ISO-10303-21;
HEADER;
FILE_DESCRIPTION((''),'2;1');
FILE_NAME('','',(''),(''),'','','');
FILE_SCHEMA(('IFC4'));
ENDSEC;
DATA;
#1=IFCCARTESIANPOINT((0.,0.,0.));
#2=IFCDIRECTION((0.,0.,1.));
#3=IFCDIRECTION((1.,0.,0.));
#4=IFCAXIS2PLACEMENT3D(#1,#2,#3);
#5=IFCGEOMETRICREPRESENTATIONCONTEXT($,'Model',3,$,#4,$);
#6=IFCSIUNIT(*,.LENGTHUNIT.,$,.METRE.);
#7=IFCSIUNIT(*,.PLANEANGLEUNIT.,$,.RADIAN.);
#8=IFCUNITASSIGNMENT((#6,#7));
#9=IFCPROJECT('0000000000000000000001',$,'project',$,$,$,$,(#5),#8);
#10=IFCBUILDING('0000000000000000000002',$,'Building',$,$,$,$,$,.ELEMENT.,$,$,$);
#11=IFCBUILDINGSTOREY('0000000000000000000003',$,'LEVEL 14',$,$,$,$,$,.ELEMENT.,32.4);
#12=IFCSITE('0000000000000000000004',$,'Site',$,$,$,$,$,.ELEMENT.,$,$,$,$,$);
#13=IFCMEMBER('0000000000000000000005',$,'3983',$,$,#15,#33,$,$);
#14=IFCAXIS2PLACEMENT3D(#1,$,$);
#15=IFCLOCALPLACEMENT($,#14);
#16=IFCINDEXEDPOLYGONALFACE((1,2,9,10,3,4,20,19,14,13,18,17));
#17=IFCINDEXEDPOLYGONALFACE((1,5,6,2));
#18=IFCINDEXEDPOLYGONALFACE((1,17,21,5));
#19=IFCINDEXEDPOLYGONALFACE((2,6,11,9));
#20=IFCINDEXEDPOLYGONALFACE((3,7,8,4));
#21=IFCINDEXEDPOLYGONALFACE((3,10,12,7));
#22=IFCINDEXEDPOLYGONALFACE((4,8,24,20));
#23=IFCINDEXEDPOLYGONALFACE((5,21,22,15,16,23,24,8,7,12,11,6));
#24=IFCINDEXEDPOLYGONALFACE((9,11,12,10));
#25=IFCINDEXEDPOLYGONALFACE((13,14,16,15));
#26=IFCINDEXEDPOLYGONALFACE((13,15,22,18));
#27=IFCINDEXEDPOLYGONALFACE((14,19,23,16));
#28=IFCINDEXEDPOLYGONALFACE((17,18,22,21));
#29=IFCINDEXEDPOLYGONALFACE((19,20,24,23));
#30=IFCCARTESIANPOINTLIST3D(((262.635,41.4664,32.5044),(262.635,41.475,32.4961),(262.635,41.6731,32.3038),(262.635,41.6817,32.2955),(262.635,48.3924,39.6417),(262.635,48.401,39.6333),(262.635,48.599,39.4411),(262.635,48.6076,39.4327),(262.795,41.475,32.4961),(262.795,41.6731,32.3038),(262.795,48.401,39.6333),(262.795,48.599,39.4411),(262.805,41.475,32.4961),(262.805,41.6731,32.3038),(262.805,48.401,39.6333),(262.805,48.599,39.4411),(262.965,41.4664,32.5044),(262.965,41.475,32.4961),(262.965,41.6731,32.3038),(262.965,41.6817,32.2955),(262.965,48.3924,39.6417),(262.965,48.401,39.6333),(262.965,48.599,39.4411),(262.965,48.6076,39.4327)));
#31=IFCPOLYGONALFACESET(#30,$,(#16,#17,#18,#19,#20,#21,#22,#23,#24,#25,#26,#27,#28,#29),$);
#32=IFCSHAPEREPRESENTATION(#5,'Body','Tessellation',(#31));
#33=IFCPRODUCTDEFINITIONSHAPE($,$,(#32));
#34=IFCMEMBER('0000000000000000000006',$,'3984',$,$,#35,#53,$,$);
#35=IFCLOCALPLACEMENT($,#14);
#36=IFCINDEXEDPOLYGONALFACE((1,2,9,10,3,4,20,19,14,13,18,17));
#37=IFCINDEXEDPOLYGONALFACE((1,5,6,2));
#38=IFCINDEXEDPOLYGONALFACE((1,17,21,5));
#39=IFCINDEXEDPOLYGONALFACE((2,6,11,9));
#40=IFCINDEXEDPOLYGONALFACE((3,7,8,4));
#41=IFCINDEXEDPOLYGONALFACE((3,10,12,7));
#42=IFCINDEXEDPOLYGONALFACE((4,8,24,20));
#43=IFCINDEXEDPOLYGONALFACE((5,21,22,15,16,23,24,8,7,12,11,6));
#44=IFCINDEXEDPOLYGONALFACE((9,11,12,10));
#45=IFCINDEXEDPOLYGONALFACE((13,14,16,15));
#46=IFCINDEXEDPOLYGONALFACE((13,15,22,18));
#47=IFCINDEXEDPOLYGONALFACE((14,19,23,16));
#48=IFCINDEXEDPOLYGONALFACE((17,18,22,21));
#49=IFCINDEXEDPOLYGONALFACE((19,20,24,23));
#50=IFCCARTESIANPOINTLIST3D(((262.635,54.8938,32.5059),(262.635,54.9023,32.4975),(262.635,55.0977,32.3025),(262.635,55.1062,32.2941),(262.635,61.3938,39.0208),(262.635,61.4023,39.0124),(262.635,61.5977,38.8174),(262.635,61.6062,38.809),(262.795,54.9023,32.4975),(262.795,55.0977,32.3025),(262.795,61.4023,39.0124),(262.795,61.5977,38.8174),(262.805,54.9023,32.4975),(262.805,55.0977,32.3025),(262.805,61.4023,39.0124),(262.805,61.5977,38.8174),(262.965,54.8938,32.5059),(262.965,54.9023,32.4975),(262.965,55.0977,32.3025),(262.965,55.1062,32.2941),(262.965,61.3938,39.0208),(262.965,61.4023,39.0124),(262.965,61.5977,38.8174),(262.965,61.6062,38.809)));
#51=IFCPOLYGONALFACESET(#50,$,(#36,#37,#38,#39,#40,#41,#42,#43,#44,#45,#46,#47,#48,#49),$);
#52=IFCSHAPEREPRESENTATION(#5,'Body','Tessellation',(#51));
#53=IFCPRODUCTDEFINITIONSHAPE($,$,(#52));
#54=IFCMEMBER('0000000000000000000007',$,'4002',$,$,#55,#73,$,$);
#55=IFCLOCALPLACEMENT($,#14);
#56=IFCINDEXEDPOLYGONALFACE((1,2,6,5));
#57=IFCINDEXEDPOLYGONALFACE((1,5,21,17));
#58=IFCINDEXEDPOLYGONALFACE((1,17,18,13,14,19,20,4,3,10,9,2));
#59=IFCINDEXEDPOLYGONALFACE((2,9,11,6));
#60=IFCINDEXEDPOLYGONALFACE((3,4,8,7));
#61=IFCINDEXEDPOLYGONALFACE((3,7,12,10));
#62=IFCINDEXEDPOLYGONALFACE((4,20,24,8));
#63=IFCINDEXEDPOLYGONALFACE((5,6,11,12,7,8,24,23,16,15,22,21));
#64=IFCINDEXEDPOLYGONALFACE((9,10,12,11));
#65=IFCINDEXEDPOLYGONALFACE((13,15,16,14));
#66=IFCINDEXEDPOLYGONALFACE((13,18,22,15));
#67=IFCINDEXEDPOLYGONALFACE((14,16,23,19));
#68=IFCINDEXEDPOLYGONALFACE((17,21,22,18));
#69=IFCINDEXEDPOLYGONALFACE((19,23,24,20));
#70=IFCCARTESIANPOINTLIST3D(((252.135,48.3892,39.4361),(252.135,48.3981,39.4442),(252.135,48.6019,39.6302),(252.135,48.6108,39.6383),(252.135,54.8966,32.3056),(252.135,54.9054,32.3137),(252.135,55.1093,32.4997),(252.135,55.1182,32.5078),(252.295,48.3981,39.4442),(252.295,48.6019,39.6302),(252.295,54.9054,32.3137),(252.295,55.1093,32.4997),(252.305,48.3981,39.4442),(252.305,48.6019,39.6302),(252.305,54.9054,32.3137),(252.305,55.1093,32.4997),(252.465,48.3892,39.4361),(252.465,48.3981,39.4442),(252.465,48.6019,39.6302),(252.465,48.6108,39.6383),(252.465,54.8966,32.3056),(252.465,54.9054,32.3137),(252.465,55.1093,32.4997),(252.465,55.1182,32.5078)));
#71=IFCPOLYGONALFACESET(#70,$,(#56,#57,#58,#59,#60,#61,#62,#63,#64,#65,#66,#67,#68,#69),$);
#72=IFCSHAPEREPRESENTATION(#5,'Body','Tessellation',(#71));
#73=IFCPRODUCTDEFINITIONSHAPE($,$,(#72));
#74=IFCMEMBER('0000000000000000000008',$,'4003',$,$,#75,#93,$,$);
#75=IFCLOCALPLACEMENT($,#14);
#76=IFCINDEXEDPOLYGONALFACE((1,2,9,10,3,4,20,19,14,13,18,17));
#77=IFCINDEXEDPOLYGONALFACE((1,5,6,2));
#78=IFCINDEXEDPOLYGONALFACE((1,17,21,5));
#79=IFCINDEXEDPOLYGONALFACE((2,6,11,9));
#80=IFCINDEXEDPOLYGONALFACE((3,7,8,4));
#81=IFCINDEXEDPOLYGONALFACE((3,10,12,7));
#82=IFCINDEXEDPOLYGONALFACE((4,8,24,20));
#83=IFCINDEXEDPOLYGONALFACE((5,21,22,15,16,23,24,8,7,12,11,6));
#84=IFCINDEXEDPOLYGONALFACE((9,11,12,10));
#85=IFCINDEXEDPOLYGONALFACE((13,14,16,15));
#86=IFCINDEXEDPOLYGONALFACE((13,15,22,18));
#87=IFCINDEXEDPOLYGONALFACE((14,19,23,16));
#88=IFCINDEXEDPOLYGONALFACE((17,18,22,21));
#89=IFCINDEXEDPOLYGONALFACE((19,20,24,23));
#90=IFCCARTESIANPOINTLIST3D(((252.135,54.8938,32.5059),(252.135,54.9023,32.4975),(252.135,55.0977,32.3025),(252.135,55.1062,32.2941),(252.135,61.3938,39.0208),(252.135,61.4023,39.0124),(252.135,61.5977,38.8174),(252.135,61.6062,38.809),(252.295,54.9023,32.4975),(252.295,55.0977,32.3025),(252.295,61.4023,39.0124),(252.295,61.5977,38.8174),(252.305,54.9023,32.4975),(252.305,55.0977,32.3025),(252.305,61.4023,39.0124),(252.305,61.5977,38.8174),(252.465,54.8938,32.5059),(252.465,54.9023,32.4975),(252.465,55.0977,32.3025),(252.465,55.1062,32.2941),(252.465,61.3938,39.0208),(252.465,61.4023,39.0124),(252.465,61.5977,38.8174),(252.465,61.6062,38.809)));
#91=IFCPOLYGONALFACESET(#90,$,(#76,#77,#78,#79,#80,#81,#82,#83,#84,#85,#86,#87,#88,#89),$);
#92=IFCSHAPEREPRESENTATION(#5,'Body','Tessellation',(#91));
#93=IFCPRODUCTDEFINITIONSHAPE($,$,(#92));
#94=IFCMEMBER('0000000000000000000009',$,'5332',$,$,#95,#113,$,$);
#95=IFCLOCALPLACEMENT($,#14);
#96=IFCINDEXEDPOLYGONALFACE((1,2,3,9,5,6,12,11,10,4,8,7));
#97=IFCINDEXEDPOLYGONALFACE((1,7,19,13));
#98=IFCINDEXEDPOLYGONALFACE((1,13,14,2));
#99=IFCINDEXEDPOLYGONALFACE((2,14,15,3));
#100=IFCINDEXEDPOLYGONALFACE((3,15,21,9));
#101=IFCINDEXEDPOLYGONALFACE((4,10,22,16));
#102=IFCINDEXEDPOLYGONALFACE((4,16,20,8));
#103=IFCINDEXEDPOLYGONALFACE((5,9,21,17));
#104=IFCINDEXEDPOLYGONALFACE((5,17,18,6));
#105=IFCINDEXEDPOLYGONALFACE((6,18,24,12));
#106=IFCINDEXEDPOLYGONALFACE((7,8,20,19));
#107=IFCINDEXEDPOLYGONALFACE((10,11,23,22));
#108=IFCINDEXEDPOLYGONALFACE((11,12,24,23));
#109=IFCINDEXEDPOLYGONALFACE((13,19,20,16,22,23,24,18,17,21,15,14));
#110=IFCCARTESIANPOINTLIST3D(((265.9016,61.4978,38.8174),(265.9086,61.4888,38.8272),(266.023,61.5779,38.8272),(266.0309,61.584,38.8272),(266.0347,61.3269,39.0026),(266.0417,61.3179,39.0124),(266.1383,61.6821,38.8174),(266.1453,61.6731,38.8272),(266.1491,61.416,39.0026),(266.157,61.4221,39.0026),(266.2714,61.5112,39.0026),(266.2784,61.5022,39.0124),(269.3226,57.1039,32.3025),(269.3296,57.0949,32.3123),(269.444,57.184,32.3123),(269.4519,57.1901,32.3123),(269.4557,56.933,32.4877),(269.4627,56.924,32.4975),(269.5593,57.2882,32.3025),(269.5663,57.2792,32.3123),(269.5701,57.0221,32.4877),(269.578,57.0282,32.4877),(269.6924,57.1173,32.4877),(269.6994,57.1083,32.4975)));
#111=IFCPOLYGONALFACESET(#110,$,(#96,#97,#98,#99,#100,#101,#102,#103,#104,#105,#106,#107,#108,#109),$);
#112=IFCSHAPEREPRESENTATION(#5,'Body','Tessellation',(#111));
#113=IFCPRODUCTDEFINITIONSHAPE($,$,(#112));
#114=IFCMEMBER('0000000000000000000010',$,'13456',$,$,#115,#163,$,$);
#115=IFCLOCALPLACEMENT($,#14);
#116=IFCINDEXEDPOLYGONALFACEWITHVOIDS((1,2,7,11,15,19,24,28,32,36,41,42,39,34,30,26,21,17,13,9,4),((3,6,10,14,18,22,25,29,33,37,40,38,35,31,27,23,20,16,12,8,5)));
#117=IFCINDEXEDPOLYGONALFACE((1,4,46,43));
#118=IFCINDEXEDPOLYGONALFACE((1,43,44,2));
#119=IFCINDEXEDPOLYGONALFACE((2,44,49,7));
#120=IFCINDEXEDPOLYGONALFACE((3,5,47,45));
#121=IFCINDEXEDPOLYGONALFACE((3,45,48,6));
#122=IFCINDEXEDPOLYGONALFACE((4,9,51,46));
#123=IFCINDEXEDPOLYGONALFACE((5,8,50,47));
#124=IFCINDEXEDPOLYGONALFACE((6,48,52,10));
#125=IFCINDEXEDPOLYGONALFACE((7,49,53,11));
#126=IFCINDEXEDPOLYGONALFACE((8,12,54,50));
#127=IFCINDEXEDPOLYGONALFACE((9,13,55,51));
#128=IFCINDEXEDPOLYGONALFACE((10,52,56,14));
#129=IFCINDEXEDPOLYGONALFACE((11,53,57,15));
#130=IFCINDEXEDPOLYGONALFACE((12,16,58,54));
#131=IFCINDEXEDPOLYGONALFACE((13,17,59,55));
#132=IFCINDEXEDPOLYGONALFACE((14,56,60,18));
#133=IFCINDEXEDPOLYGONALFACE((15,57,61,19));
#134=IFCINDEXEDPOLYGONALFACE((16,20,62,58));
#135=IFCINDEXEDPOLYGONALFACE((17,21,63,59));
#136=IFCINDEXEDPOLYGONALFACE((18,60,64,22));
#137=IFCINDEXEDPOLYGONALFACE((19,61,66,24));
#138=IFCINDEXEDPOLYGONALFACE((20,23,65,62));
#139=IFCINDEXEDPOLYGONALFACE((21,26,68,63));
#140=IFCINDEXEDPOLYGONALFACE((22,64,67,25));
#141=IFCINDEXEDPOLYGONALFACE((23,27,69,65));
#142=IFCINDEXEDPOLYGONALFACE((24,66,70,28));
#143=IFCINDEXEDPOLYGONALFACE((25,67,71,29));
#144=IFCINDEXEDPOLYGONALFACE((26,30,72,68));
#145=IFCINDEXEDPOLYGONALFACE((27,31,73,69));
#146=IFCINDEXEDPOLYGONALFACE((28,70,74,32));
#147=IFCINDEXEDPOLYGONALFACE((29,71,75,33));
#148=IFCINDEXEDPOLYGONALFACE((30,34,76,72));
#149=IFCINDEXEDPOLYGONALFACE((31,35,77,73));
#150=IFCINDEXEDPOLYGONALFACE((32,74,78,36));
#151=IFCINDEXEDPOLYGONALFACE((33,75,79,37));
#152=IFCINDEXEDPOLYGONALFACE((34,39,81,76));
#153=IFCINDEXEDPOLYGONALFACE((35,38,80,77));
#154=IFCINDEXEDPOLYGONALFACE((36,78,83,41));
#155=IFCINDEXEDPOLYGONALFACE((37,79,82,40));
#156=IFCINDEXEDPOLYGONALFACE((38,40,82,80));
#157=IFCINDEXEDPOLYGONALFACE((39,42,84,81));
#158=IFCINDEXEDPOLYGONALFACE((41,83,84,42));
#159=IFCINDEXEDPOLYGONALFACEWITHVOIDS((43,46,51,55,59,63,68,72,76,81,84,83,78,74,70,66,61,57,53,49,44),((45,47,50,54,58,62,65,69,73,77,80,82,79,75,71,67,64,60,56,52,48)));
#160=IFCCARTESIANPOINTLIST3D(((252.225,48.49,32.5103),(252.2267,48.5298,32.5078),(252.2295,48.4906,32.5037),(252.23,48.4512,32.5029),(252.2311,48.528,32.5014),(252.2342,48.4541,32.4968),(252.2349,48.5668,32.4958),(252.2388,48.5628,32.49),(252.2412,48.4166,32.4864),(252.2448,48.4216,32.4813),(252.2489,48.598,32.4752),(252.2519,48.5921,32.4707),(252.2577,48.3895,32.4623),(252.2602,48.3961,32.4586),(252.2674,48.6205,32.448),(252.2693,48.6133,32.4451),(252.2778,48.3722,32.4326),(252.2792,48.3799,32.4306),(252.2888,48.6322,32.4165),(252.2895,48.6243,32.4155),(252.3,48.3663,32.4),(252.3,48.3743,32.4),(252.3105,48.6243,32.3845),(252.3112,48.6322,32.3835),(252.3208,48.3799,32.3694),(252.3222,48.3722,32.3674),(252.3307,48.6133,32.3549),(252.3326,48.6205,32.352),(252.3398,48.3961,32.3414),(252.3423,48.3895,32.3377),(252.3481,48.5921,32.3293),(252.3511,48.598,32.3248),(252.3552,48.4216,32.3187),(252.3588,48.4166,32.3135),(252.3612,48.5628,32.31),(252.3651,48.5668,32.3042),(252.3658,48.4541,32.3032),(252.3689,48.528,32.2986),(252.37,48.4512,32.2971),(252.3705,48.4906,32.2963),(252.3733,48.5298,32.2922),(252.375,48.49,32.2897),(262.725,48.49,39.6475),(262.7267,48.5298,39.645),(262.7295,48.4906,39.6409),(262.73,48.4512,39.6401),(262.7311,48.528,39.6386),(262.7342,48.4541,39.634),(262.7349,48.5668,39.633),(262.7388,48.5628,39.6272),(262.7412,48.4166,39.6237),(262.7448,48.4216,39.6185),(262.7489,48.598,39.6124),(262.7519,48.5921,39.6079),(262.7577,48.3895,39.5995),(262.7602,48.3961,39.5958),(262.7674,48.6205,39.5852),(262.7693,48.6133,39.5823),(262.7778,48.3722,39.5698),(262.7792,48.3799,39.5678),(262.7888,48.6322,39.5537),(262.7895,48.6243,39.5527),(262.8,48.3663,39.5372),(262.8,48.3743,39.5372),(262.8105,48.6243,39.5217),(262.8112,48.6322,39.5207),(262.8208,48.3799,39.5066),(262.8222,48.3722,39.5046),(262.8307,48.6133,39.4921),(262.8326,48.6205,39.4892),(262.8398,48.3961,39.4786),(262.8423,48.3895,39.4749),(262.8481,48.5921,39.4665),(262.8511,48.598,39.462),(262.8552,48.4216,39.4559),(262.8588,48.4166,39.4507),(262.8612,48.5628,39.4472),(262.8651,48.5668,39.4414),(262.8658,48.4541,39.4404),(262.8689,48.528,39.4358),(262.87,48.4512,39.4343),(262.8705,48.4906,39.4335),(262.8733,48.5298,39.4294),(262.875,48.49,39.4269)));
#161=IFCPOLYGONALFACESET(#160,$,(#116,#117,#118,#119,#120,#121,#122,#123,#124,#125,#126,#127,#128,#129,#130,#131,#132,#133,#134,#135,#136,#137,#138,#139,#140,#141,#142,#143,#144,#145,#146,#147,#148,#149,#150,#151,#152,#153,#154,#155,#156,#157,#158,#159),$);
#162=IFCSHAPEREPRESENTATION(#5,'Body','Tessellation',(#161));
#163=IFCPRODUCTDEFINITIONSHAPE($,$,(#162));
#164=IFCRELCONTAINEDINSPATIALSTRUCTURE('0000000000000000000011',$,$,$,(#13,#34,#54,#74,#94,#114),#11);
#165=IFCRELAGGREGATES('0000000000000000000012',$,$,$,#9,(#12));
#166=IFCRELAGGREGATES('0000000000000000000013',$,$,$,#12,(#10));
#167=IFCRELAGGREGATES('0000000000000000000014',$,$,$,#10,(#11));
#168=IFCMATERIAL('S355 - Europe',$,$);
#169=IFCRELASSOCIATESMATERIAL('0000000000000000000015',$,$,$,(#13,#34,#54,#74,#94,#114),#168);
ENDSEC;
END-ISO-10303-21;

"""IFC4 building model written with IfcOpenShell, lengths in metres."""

from ifc_helpers import new_model, si_unit, frame, origin_with_axes, origin_2d_with_axis, place, context, project, spatial, hollow_circle, i_section, extrude, material, material_profile, profile_set, profile_usage, element, save


model = new_model("IFC4")

# Units and contexts
model_context = context("Model", 3, world=origin_with_axes())
ifc_project = project(units=[si_unit("LENGTHUNIT", "METRE"), si_unit("PLANEANGLEUNIT", "RADIAN")], contexts=[model_context])

# Site, building, storey
site = spatial("IfcSite", under=ifc_project, Name="Site", CompositionType="ELEMENT")
building = spatial("IfcBuilding", under=site, Name="Building", CompositionType="ELEMENT")
storey = spatial("IfcBuildingStorey", under=building, Name="LEVEL 14", CompositionType="ELEMENT", Elevation=32.4)

# Shared definitions
ifc_material = material(Name="S355 - Europe")

# Members
ifc_material_profile_1 = material_profile(ifc_material, i_section(OverallWidth=0.33, OverallDepth=0.3, WebThickness=0.01, FlangeThickness=0.012, at=origin_2d_with_axis()))
ifc_profile_set_1 = profile_set([ifc_material_profile_1])
ifc_profile_usage_1 = profile_usage(ifc_profile_set_1, cardinal=10)
member_1_placement = place(None, frame((262.8, 48.5, 39.5372), z_axis=(0.0, -0.696404, -0.71765), x_axis=(1.0, 0.0, 0.0)))
element("IfcMember", 1, at=member_1_placement, inside=storey, material=ifc_profile_usage_1, Name="3983", context=model_context, shape_type="SweptSolid", body=[
    extrude(i_section(OverallWidth=0.33, OverallDepth=0.3, WebThickness=0.01, FlangeThickness=0.012, at=origin_2d_with_axis()), origin_with_axes(), (0.0, 0.0, 1.0), 9.9453),
])
ifc_material_profile_2 = material_profile(ifc_material, i_section(OverallWidth=0.33, OverallDepth=0.3, WebThickness=0.01, FlangeThickness=0.012, at=origin_2d_with_axis()))
ifc_profile_set_2 = profile_set([ifc_material_profile_2])
ifc_profile_usage_2 = profile_usage(ifc_profile_set_2, cardinal=10)
member_2_placement = place(None, frame((262.8, 55.0, 32.4), z_axis=(0.0, 0.706297, 0.707916), x_axis=(-1.0, 0.0, 0.0)))
element("IfcMember", 2, at=member_2_placement, inside=storey, material=ifc_profile_usage_2, Name="3984", context=model_context, shape_type="SweptSolid", body=[
    extrude(i_section(OverallWidth=0.33, OverallDepth=0.3, WebThickness=0.01, FlangeThickness=0.012, at=origin_2d_with_axis()), origin_with_axes(), (0.0, 0.0, 1.0), 9.2029),
])
ifc_material_profile_3 = material_profile(ifc_material, i_section(OverallWidth=0.33, OverallDepth=0.3, WebThickness=0.01, FlangeThickness=0.012, at=origin_2d_with_axis()))
ifc_profile_set_3 = profile_set([ifc_material_profile_3])
ifc_profile_usage_3 = profile_usage(ifc_profile_set_3, cardinal=10)
member_3_placement = place(None, frame((252.3, 48.5, 39.5372), z_axis=(0.0, 0.674095, -0.738644), x_axis=(-1.0, 0.0, 0.0)))
element("IfcMember", 3, at=member_3_placement, inside=storey, material=ifc_profile_usage_3, Name="4002", context=model_context, shape_type="SweptSolid", body=[
    extrude(i_section(OverallWidth=0.33, OverallDepth=0.3, WebThickness=0.01, FlangeThickness=0.012, at=origin_2d_with_axis()), origin_with_axes(), (0.0, 0.0, 1.0), 9.6535),
])
ifc_material_profile_4 = material_profile(ifc_material, i_section(OverallWidth=0.33, OverallDepth=0.3, WebThickness=0.01, FlangeThickness=0.012, at=origin_2d_with_axis()))
ifc_profile_set_4 = profile_set([ifc_material_profile_4])
ifc_profile_usage_4 = profile_usage(ifc_profile_set_4, cardinal=10)
member_4_placement = place(None, frame((252.3, 55.0, 32.4), z_axis=(0.0, 0.706297, 0.707916), x_axis=(-1.0, 0.0, 0.0)))
element("IfcMember", 4, at=member_4_placement, inside=storey, material=ifc_profile_usage_4, Name="4003", context=model_context, shape_type="SweptSolid", body=[
    extrude(i_section(OverallWidth=0.33, OverallDepth=0.3, WebThickness=0.01, FlangeThickness=0.012, at=origin_2d_with_axis()), origin_with_axes(), (0.0, 0.0, 1.0), 9.2029),
])
ifc_material_profile_5 = material_profile(ifc_material, i_section(OverallWidth=0.3, OverallDepth=0.3, WebThickness=0.01, FlangeThickness=0.015, at=origin_2d_with_axis()))
ifc_profile_set_5 = profile_set([ifc_material_profile_5])
ifc_profile_usage_5 = profile_usage(ifc_profile_set_5, cardinal=10)
member_5_placement = place(None, frame((269.511, 57.1061, 32.4), z_axis=(-0.39916, 0.512677, 0.760154), x_axis=(-0.789046, -0.614335, 0.0)))
element("IfcMember", 5, at=member_5_placement, inside=storey, material=ifc_profile_usage_5, Name="5332", context=model_context, shape_type="SweptSolid", body=[
    extrude(i_section(OverallWidth=0.3, OverallDepth=0.3, WebThickness=0.01, FlangeThickness=0.015, at=origin_2d_with_axis()), origin_with_axes(), (0.0, 0.0, 1.0), 8.5705),
])
ifc_material_profile_6 = material_profile(ifc_material, hollow_circle(Radius=0.1337, WallThickness=0.008, at=origin_2d_with_axis()))
ifc_profile_set_6 = profile_set([ifc_material_profile_6])
ifc_profile_usage_6 = profile_usage(ifc_profile_set_6, cardinal=10)
member_6_placement = place(None, frame((262.8, 48.5, 39.5372), z_axis=(-0.827029, 0.0, -0.562159), x_axis=(0.0, -1.0, 0.0)))
element("IfcMember", 6, at=member_6_placement, inside=storey, material=ifc_profile_usage_6, Name="13456", context=model_context, shape_type="SweptSolid", body=[
    extrude(hollow_circle(Radius=0.1337, WallThickness=0.008, at=origin_2d_with_axis()), origin_with_axes(), (0.0, 0.0, 1.0), 12.696),
])

save(model, "model.ifc")
